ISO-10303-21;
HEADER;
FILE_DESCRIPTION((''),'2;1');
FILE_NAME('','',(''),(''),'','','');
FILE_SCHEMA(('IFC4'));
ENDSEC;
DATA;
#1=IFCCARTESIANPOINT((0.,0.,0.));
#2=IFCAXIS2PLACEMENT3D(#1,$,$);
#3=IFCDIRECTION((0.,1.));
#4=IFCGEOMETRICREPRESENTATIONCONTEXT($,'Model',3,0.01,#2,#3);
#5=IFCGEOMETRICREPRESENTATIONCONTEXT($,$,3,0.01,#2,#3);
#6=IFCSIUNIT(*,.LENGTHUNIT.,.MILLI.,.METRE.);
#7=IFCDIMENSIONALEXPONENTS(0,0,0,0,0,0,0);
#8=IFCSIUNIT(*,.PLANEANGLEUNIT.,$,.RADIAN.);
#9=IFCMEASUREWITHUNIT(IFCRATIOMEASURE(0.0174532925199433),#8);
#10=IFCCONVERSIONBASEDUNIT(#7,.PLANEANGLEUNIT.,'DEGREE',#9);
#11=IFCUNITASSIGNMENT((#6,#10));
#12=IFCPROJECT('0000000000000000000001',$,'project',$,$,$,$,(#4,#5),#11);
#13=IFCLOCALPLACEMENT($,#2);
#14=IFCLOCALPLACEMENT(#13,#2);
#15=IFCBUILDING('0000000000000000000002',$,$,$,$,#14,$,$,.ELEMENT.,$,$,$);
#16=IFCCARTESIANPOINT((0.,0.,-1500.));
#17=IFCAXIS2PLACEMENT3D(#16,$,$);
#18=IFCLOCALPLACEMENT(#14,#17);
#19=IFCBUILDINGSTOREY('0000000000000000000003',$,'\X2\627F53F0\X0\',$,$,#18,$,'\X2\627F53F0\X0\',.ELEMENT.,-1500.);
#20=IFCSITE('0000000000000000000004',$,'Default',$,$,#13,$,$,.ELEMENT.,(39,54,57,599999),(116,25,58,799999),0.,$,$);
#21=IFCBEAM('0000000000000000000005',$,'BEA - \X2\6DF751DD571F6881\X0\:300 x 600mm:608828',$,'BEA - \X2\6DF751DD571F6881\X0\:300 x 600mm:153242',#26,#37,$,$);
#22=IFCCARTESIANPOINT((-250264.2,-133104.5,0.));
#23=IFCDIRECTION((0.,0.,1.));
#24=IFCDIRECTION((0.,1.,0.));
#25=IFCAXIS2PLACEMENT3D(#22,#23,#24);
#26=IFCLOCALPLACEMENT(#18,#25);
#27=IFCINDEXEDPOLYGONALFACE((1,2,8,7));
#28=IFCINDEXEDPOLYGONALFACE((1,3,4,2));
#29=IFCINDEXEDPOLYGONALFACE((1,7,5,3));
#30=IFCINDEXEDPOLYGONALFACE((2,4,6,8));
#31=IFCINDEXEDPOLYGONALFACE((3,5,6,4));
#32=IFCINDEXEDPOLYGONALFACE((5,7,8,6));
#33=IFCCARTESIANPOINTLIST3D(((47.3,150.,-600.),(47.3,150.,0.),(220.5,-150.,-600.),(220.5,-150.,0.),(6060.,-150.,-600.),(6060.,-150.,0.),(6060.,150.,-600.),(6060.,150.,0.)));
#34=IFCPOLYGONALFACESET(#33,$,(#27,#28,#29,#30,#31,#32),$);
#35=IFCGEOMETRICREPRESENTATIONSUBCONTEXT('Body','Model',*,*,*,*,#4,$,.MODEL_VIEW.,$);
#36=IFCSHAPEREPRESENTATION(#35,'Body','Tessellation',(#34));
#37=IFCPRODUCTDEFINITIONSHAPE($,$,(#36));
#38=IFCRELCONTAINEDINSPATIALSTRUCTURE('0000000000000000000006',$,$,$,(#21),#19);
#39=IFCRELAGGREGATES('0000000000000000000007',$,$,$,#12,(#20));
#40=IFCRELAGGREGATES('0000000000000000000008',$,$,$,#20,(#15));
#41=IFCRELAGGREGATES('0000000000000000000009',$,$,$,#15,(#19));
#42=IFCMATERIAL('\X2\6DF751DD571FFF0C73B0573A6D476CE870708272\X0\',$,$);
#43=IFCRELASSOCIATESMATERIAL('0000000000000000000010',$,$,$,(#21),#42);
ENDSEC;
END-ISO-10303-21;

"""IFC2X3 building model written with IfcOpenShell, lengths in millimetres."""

from ifc_helpers import new_model, entity, si_unit, converted_unit, direction, frame, frame_2d, origin, place, context, subcontext, project, spatial, rectangle, extrude, clip, halfspace, material, element, save


model = new_model("IFC2X3")

# Units and contexts
model_context = context("Model", 3, precision=0.01, world=origin(), true_north=direction((0.0, 1.0)))
context_of_model = context(None, 3, precision=0.01, world=origin(), true_north=direction((0.0, 1.0)))
body_context = subcontext(model_context, "Body", "Model", "MODEL_VIEW")
ifc_project = project(units=[si_unit("LENGTHUNIT", "METRE", prefix="MILLI"), converted_unit("PLANEANGLEUNIT", "DEGREE", entity("IfcRatioMeasure", 0.0174532925199433), si_unit("PLANEANGLEUNIT", "RADIAN"), dimensions=[0, 0, 0, 0, 0, 0, 0])], contexts=[model_context, context_of_model])

# Site, building, storey
site_placement = place(None, origin())
site = spatial("IfcSite", under=ifc_project, at=site_placement, Name="Default", CompositionType="ELEMENT", RefLatitude=(39, 54, 57, 599999), RefLongitude=(116, 25, 58, 799999), RefElevation=0.0)
building_placement = place(site_placement, origin())
building = spatial("IfcBuilding", under=site, at=building_placement, CompositionType="ELEMENT")
storey_placement = place(building_placement, frame((0.0, 0.0, -1500.0)))
storey = spatial("IfcBuildingStorey", under=building, at=storey_placement, Name="承台", LongName="承台", CompositionType="ELEMENT", Elevation=-1500.0)

# Shared definitions
ifc_material_1 = material(Name="混凝土，现场浇注灰色")

# Beam
beam_1_placement = place(storey_placement, frame((-250264.2, -133104.5, 0.0), z_axis=(0.0, 0.0, 1.0), x_axis=(0.0, 1.0, 0.0)))
element("IfcBeam", 1, at=beam_1_placement, inside=storey, material=ifc_material_1, Name="BEA - 混凝土梁:300 x 600mm:608828", ObjectType="BEA - 混凝土梁:300 x 600mm:153242", context=body_context, shape_type="Clipping", body=[
    clip(extrude(rectangle(XDim=600.0, YDim=300.0, at=frame_2d((0.0, 0.0), x_axis=(1.0, 0.0))), frame((47.3, 0.0, -300.0), z_axis=(1.0, 0.0, 0.0), x_axis=(0.0, 0.0, -1.0)), (0.0, 0.0, 1.0), 6012.7), halfspace(frame((534.0, -693.3, 0.0), z_axis=(-0.866125, -0.499827, 0.0), x_axis=(0.499827, -0.866125, 0.0)), False)),
])

save(model, "model.ifc")
